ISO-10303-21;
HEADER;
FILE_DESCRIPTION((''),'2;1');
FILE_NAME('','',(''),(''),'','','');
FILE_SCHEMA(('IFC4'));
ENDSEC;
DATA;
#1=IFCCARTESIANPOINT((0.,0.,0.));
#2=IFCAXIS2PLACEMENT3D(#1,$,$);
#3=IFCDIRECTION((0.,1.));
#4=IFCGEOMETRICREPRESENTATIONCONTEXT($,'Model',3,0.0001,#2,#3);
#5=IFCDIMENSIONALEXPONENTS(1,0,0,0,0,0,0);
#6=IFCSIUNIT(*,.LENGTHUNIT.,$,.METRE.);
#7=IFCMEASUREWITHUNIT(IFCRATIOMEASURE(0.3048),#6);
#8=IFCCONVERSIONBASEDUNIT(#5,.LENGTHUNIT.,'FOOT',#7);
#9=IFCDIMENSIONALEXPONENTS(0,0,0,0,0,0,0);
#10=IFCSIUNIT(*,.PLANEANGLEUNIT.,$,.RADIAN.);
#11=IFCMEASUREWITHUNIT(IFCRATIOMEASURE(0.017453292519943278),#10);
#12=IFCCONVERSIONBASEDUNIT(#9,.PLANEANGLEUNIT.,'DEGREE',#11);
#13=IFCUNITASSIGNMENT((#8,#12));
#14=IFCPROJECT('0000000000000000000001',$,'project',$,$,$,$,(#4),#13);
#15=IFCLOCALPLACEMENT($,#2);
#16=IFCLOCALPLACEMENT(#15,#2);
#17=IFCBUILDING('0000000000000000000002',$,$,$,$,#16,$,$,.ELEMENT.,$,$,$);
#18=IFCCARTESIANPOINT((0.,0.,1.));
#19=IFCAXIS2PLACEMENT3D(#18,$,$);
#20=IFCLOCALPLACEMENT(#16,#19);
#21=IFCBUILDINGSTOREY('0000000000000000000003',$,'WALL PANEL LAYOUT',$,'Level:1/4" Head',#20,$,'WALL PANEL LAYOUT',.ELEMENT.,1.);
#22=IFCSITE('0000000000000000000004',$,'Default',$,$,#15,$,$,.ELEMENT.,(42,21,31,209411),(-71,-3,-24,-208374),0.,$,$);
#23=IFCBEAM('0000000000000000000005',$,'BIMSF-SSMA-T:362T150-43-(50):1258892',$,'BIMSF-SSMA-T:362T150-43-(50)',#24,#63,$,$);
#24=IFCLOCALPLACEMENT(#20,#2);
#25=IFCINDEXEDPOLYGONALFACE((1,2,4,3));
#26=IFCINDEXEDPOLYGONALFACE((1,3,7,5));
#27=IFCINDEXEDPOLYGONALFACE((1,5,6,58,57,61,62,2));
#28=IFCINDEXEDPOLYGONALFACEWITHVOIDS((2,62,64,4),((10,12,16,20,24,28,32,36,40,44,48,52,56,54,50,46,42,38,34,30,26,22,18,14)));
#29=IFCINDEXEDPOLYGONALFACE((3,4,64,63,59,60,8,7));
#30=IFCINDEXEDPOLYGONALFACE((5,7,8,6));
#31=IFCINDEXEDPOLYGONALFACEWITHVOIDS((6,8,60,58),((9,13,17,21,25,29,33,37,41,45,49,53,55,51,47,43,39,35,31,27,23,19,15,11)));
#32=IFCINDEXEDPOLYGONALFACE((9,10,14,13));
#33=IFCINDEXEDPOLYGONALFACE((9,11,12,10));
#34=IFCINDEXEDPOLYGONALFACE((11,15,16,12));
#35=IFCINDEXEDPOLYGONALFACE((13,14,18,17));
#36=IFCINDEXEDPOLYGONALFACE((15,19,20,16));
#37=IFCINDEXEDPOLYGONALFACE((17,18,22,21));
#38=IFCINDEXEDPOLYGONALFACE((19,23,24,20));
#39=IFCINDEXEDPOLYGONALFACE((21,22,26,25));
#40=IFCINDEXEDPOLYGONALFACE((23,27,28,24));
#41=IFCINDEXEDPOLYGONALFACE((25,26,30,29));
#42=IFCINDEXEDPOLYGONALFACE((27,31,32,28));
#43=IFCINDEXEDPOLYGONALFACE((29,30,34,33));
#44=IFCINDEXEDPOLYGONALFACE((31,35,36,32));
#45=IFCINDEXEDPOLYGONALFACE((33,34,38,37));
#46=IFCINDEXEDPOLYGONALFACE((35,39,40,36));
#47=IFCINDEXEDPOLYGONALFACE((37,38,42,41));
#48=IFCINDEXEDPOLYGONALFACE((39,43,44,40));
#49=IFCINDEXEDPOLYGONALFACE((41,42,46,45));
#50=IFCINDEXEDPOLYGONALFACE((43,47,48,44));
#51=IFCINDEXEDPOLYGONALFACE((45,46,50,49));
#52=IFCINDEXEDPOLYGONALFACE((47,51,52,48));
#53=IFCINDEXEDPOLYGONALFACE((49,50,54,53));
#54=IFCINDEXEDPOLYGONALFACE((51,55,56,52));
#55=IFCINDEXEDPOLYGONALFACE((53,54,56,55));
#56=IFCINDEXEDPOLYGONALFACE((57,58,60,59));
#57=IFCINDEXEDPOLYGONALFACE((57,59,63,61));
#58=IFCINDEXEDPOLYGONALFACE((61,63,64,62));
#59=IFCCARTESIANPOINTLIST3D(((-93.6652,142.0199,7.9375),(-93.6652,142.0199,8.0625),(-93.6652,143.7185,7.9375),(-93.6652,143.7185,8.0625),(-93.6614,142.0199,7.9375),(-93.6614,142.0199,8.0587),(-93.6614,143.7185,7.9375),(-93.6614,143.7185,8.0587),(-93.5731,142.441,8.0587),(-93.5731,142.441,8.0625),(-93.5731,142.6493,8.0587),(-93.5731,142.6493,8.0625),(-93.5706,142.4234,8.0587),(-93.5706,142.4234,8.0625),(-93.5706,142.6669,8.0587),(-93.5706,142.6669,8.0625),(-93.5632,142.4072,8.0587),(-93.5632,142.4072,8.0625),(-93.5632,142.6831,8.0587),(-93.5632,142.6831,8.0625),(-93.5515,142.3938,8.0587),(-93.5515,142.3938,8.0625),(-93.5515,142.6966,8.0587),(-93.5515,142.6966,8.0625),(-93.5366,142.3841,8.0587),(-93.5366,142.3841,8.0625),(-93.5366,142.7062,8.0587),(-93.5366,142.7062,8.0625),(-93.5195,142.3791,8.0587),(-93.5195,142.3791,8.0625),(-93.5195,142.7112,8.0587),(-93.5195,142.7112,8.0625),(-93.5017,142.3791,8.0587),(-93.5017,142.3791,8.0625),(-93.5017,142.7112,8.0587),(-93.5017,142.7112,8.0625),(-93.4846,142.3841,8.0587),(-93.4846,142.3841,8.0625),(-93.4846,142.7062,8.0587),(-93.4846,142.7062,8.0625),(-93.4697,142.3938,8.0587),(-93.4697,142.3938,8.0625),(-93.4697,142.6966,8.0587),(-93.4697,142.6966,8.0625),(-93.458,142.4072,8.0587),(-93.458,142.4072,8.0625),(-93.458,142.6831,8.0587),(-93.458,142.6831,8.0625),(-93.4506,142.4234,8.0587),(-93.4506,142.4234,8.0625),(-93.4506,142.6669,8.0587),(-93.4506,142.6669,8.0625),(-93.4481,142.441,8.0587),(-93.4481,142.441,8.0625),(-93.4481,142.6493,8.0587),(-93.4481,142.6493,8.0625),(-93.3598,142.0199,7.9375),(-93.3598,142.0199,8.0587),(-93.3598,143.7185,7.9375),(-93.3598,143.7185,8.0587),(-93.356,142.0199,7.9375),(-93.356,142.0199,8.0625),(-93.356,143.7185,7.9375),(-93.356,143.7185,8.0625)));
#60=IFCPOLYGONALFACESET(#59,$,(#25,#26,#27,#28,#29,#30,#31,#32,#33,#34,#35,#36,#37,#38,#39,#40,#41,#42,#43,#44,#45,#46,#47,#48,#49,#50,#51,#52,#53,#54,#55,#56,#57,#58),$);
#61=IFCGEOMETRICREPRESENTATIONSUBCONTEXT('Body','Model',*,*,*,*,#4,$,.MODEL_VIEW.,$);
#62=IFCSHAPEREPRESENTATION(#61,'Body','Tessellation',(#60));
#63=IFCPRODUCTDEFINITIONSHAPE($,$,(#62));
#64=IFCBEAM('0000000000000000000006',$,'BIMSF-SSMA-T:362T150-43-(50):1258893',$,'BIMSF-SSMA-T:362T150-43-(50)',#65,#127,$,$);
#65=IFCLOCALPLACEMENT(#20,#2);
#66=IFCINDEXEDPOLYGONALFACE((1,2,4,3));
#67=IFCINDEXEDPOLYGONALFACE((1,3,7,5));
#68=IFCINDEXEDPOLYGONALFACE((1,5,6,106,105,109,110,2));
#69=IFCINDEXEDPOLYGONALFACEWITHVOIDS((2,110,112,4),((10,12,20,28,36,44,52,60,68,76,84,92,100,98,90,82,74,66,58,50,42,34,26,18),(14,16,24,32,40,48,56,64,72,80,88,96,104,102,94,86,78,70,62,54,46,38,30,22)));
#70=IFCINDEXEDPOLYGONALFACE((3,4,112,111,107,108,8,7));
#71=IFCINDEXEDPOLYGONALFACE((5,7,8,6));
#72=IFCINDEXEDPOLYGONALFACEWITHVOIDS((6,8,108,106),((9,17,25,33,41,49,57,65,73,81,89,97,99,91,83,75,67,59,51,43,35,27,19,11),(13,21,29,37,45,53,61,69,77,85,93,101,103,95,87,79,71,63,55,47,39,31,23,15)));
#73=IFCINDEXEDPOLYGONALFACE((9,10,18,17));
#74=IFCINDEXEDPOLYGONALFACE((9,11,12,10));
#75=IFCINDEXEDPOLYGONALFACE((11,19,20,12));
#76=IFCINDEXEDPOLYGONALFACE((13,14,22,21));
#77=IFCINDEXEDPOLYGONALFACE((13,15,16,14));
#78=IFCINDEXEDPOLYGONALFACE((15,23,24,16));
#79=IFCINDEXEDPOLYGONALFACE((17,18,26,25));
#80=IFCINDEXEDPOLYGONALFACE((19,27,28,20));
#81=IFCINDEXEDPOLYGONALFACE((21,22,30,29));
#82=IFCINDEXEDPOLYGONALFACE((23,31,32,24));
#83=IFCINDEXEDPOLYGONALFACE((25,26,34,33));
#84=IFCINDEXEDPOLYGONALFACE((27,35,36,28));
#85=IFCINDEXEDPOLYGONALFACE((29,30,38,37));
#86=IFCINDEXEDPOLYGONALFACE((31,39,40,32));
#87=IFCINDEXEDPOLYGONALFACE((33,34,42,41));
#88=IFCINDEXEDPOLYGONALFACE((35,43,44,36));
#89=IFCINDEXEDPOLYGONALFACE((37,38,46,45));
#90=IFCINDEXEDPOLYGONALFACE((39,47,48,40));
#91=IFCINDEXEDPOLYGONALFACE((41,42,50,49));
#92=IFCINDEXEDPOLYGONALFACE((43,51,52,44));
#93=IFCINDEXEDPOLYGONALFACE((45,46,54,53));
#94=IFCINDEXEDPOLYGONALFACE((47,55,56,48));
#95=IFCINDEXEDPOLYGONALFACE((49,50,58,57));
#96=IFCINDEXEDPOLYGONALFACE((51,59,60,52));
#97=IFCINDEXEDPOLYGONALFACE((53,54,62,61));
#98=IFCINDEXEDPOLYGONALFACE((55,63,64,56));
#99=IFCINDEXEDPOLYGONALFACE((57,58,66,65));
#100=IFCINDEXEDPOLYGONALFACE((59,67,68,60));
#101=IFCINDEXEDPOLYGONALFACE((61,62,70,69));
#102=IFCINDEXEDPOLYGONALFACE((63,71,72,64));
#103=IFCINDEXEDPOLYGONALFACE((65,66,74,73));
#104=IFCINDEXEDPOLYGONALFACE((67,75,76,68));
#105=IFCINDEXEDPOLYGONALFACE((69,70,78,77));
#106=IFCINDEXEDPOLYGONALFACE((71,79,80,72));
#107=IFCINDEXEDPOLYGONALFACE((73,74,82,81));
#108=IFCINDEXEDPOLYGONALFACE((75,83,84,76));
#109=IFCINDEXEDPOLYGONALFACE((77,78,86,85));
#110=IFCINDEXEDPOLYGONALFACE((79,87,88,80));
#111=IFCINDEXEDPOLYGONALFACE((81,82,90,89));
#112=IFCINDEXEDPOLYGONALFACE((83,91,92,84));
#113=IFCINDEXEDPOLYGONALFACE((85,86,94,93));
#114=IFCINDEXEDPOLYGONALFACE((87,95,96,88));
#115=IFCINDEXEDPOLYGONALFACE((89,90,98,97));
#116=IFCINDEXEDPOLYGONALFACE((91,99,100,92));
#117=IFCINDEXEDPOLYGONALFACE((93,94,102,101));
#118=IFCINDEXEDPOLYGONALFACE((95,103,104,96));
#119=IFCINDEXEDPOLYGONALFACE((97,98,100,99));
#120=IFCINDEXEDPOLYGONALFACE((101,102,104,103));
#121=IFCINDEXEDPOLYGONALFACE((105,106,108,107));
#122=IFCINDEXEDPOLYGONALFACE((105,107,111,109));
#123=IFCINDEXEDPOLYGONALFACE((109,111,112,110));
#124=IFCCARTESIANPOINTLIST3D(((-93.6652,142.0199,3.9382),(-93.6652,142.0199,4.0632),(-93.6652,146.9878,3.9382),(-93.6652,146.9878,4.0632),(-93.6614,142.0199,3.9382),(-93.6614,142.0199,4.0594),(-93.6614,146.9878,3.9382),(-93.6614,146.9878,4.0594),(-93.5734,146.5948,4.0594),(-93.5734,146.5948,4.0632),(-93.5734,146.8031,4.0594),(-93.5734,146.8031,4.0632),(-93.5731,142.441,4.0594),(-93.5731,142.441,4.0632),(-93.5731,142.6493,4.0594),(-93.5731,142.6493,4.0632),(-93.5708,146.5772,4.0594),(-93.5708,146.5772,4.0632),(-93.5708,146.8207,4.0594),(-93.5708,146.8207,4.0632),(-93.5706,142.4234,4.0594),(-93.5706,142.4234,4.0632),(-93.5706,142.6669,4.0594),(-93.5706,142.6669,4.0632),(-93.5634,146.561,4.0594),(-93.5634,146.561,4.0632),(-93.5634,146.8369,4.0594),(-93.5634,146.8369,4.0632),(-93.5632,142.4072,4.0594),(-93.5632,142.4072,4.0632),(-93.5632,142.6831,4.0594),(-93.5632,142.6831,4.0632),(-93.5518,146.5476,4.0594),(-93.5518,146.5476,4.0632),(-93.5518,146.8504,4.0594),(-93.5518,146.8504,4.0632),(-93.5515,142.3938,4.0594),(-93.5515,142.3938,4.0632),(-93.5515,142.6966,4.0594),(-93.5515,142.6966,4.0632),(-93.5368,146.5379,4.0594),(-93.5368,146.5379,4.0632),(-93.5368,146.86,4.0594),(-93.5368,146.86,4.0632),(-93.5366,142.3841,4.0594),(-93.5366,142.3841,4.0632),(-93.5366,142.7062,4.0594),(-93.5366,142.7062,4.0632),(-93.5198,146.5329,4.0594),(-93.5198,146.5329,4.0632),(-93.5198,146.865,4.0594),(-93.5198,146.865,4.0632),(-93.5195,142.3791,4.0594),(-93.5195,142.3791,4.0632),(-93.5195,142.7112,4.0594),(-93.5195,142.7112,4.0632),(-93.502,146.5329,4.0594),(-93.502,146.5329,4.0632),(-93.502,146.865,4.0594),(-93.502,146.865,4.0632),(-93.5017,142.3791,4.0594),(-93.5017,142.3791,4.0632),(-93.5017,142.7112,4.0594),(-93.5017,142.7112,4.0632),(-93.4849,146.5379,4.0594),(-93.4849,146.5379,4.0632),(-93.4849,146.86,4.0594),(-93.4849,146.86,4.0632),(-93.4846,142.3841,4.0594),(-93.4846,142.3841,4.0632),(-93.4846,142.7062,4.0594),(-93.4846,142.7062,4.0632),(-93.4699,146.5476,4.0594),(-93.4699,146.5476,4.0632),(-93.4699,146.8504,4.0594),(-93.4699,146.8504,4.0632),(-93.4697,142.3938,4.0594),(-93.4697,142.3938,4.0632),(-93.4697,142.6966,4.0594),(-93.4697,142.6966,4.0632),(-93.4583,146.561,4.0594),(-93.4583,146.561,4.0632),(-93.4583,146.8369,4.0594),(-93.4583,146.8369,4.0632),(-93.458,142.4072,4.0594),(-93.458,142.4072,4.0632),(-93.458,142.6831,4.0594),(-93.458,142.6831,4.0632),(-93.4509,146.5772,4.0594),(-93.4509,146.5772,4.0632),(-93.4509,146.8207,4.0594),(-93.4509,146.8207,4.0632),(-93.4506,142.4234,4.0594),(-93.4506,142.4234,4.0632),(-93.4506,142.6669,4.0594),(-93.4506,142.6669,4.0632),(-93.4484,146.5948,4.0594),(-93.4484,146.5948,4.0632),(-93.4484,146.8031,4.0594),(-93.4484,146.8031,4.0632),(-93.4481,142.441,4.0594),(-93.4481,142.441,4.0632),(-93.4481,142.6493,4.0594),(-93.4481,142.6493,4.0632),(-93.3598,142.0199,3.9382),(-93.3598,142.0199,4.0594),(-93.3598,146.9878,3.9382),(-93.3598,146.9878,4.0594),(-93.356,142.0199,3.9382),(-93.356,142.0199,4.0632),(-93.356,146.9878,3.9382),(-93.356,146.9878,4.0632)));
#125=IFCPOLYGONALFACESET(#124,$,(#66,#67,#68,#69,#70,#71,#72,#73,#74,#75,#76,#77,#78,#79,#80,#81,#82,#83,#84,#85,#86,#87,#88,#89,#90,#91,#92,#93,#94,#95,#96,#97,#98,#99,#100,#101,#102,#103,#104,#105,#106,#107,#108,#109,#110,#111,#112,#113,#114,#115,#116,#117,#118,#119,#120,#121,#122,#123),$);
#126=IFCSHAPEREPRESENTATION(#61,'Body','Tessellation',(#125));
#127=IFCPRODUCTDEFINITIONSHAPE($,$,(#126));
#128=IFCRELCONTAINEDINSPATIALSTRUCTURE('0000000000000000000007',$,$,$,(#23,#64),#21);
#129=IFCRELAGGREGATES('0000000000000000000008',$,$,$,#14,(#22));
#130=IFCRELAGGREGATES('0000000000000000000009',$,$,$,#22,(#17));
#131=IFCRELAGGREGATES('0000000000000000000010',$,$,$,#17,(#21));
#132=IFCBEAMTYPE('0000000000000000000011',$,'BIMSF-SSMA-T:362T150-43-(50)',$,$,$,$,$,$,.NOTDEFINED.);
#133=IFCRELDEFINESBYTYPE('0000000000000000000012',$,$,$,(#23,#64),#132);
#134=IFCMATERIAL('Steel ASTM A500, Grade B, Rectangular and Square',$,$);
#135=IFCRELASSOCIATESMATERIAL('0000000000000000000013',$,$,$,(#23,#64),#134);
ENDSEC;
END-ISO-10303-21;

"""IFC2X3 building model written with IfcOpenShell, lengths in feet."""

from ifc_helpers import new_model, entity, si_unit, converted_unit, direction, frame, frame_2d, origin, place, context, subcontext, project, spatial, polyline, circle_curve, parameter, trimmed, segment, composite_curve, outline, extrude, boolean, material, type_object, element, save


model = new_model("IFC2X3")

# Units and contexts
model_context = context("Model", 3, precision=0.0001, world=origin(), true_north=direction((0.0, 1.0)))
body_context = subcontext(model_context, "Body", "Model", "MODEL_VIEW")
ifc_project = project(units=[converted_unit("LENGTHUNIT", "FOOT", entity("IfcRatioMeasure", 0.3048), si_unit("LENGTHUNIT", "METRE"), dimensions=[1, 0, 0, 0, 0, 0, 0]), converted_unit("PLANEANGLEUNIT", "DEGREE", entity("IfcRatioMeasure", 0.017453292519943278), si_unit("PLANEANGLEUNIT", "RADIAN"), dimensions=[0, 0, 0, 0, 0, 0, 0])], contexts=[model_context])

# Site, building, storey
site_placement = place(None, origin())
site = spatial("IfcSite", under=ifc_project, at=site_placement, Name="Default", CompositionType="ELEMENT", RefLatitude=(42, 21, 31, 209411), RefLongitude=(-71, -3, -24, -208374), RefElevation=0.0)
building_placement = place(site_placement, origin())
building = spatial("IfcBuilding", under=site, at=building_placement, CompositionType="ELEMENT")
storey_placement = place(building_placement, frame((0.0, 0.0, 1.0)))
storey = spatial("IfcBuildingStorey", under=building, at=storey_placement, Name="WALL PANEL LAYOUT", ObjectType="Level:1/4\" Head", LongName="WALL PANEL LAYOUT", CompositionType="ELEMENT", Elevation=1.0)

# Beams
ifc_material = material(Name="Steel ASTM A500, Grade B, Rectangular and Square")
beam_type_1 = type_object("IfcBeamType", Name="BIMSF-SSMA-T:362T150-43-(50)", PredefinedType="NOTDEFINED")
beam_1_placement = place(storey_placement, frame((-93.5106, 143.7185, 8.0), z_axis=(0.0, 0.0, 1.0), x_axis=(0.0, -1.0, 0.0)))
element("IfcBeam", 1, at=beam_1_placement, inside=storey, type_object=beam_type_1, material=ifc_material, Name="BIMSF-SSMA-T:362T150-43-(50):1258892", ObjectType="BIMSF-SSMA-T:362T150-43-(50)", context=body_context, shape_type="SweptSolid", body=[
    boolean("DIFFERENCE", extrude(outline(polyline([(-0.0634, -0.1546), (0.0616, -0.1546), (0.0616, -0.1508), (-0.0597, -0.1508), (-0.0597, 0.1508), (0.0616, 0.1508), (0.0616, 0.1546), (-0.0634, 0.1546), (-0.0634, -0.1546)])), frame((0.0, 0.0, -0.0009), z_axis=(1.0, 0.0, 0.0), x_axis=(0.0, 0.0, -1.0)), (0.0, 0.0, 1.0), 1.6986), extrude(outline(composite_curve([segment(trimmed(circle_curve(frame_2d((0.1042, 0.0), x_axis=(1.0, 0.0)), 0.0625), [parameter(270.0)], [parameter(90.0)], True, "PARAMETER"), True, "CONTINUOUS"), segment(polyline([(0.1042, 0.0625), (-0.1042, 0.0625)]), True, "CONTINUOUS"), segment(trimmed(circle_curve(frame_2d((-0.1042, 0.0), x_axis=(1.0, 0.0)), 0.0625), [parameter(90.0)], [parameter(270.0)], True, "PARAMETER"), True, "CONTINUOUS"), segment(polyline([(-0.1042, -0.0625), (0.1042, -0.0625)]), True, "CONTINUOUS")], self_intersect=False)), frame((1.1734, 0.0, 0.0587)), (0.0, 0.0, 1.0), 0.0038)),
])
beam_2_placement = place(storey_placement, frame((-93.5106, 146.9878, 4.0007), z_axis=(0.0, 0.0, 1.0), x_axis=(0.0, -1.0, 0.0)))
element("IfcBeam", 2, at=beam_2_placement, inside=storey, type_object=beam_type_1, material=ifc_material, Name="BIMSF-SSMA-T:362T150-43-(50):1258893", ObjectType="BIMSF-SSMA-T:362T150-43-(50)", context=body_context, shape_type="SweptSolid", body=[
    boolean("DIFFERENCE", boolean("DIFFERENCE", extrude(outline(polyline([(-0.0634, -0.1546), (0.0616, -0.1546), (0.0616, -0.1508), (-0.0597, -0.1508), (-0.0597, 0.1508), (0.0616, 0.1508), (0.0616, 0.1546), (-0.0634, 0.1546), (-0.0634, -0.1546)])), frame((0.0, 0.0, -0.0009), z_axis=(1.0, 0.0, 0.0), x_axis=(0.0, 0.0, -1.0)), (0.0, 0.0, 1.0), 4.9679), extrude(outline(composite_curve([segment(trimmed(circle_curve(frame_2d((0.1042, 0.0), x_axis=(1.0, 0.0)), 0.0625), [parameter(270.0)], [parameter(90.0)], True, "PARAMETER"), True, "CONTINUOUS"), segment(polyline([(0.1042, 0.0625), (-0.1042, 0.0625)]), True, "CONTINUOUS"), segment(trimmed(circle_curve(frame_2d((-0.1042, 0.0), x_axis=(1.0, 0.0)), 0.0625), [parameter(90.0)], [parameter(270.0)], True, "PARAMETER"), True, "CONTINUOUS"), segment(polyline([(-0.1042, -0.0625), (0.1042, -0.0625)]), True, "CONTINUOUS")], self_intersect=False)), frame((4.4426, 0.0, 0.0587)), (0.0, 0.0, 1.0), 0.0038)), extrude(outline(composite_curve([segment(polyline([(-0.1042, -0.0625), (0.1042, -0.0625)]), True, "CONTINUOUS"), segment(trimmed(circle_curve(frame_2d((0.1042, 0.0), x_axis=(1.0, 0.0)), 0.0625), [parameter(270.0)], [parameter(90.0)], True, "PARAMETER"), True, "CONTINUOUS"), segment(polyline([(0.1042, 0.0625), (-0.1042, 0.0625)]), True, "CONTINUOUS"), segment(trimmed(circle_curve(frame_2d((-0.1042, 0.0), x_axis=(1.0, 0.0)), 0.0625), [parameter(90.0)], [parameter(270.0)], True, "PARAMETER"), True, "CONTINUOUS")], self_intersect=False)), frame((0.2888, -0.0003, 0.0625), z_axis=(0.0, 0.0, -1.0), x_axis=(1.0, 0.0, 0.0)), (0.0, 0.0, 1.0), 0.0038)),
])

save(model, "model.ifc")
